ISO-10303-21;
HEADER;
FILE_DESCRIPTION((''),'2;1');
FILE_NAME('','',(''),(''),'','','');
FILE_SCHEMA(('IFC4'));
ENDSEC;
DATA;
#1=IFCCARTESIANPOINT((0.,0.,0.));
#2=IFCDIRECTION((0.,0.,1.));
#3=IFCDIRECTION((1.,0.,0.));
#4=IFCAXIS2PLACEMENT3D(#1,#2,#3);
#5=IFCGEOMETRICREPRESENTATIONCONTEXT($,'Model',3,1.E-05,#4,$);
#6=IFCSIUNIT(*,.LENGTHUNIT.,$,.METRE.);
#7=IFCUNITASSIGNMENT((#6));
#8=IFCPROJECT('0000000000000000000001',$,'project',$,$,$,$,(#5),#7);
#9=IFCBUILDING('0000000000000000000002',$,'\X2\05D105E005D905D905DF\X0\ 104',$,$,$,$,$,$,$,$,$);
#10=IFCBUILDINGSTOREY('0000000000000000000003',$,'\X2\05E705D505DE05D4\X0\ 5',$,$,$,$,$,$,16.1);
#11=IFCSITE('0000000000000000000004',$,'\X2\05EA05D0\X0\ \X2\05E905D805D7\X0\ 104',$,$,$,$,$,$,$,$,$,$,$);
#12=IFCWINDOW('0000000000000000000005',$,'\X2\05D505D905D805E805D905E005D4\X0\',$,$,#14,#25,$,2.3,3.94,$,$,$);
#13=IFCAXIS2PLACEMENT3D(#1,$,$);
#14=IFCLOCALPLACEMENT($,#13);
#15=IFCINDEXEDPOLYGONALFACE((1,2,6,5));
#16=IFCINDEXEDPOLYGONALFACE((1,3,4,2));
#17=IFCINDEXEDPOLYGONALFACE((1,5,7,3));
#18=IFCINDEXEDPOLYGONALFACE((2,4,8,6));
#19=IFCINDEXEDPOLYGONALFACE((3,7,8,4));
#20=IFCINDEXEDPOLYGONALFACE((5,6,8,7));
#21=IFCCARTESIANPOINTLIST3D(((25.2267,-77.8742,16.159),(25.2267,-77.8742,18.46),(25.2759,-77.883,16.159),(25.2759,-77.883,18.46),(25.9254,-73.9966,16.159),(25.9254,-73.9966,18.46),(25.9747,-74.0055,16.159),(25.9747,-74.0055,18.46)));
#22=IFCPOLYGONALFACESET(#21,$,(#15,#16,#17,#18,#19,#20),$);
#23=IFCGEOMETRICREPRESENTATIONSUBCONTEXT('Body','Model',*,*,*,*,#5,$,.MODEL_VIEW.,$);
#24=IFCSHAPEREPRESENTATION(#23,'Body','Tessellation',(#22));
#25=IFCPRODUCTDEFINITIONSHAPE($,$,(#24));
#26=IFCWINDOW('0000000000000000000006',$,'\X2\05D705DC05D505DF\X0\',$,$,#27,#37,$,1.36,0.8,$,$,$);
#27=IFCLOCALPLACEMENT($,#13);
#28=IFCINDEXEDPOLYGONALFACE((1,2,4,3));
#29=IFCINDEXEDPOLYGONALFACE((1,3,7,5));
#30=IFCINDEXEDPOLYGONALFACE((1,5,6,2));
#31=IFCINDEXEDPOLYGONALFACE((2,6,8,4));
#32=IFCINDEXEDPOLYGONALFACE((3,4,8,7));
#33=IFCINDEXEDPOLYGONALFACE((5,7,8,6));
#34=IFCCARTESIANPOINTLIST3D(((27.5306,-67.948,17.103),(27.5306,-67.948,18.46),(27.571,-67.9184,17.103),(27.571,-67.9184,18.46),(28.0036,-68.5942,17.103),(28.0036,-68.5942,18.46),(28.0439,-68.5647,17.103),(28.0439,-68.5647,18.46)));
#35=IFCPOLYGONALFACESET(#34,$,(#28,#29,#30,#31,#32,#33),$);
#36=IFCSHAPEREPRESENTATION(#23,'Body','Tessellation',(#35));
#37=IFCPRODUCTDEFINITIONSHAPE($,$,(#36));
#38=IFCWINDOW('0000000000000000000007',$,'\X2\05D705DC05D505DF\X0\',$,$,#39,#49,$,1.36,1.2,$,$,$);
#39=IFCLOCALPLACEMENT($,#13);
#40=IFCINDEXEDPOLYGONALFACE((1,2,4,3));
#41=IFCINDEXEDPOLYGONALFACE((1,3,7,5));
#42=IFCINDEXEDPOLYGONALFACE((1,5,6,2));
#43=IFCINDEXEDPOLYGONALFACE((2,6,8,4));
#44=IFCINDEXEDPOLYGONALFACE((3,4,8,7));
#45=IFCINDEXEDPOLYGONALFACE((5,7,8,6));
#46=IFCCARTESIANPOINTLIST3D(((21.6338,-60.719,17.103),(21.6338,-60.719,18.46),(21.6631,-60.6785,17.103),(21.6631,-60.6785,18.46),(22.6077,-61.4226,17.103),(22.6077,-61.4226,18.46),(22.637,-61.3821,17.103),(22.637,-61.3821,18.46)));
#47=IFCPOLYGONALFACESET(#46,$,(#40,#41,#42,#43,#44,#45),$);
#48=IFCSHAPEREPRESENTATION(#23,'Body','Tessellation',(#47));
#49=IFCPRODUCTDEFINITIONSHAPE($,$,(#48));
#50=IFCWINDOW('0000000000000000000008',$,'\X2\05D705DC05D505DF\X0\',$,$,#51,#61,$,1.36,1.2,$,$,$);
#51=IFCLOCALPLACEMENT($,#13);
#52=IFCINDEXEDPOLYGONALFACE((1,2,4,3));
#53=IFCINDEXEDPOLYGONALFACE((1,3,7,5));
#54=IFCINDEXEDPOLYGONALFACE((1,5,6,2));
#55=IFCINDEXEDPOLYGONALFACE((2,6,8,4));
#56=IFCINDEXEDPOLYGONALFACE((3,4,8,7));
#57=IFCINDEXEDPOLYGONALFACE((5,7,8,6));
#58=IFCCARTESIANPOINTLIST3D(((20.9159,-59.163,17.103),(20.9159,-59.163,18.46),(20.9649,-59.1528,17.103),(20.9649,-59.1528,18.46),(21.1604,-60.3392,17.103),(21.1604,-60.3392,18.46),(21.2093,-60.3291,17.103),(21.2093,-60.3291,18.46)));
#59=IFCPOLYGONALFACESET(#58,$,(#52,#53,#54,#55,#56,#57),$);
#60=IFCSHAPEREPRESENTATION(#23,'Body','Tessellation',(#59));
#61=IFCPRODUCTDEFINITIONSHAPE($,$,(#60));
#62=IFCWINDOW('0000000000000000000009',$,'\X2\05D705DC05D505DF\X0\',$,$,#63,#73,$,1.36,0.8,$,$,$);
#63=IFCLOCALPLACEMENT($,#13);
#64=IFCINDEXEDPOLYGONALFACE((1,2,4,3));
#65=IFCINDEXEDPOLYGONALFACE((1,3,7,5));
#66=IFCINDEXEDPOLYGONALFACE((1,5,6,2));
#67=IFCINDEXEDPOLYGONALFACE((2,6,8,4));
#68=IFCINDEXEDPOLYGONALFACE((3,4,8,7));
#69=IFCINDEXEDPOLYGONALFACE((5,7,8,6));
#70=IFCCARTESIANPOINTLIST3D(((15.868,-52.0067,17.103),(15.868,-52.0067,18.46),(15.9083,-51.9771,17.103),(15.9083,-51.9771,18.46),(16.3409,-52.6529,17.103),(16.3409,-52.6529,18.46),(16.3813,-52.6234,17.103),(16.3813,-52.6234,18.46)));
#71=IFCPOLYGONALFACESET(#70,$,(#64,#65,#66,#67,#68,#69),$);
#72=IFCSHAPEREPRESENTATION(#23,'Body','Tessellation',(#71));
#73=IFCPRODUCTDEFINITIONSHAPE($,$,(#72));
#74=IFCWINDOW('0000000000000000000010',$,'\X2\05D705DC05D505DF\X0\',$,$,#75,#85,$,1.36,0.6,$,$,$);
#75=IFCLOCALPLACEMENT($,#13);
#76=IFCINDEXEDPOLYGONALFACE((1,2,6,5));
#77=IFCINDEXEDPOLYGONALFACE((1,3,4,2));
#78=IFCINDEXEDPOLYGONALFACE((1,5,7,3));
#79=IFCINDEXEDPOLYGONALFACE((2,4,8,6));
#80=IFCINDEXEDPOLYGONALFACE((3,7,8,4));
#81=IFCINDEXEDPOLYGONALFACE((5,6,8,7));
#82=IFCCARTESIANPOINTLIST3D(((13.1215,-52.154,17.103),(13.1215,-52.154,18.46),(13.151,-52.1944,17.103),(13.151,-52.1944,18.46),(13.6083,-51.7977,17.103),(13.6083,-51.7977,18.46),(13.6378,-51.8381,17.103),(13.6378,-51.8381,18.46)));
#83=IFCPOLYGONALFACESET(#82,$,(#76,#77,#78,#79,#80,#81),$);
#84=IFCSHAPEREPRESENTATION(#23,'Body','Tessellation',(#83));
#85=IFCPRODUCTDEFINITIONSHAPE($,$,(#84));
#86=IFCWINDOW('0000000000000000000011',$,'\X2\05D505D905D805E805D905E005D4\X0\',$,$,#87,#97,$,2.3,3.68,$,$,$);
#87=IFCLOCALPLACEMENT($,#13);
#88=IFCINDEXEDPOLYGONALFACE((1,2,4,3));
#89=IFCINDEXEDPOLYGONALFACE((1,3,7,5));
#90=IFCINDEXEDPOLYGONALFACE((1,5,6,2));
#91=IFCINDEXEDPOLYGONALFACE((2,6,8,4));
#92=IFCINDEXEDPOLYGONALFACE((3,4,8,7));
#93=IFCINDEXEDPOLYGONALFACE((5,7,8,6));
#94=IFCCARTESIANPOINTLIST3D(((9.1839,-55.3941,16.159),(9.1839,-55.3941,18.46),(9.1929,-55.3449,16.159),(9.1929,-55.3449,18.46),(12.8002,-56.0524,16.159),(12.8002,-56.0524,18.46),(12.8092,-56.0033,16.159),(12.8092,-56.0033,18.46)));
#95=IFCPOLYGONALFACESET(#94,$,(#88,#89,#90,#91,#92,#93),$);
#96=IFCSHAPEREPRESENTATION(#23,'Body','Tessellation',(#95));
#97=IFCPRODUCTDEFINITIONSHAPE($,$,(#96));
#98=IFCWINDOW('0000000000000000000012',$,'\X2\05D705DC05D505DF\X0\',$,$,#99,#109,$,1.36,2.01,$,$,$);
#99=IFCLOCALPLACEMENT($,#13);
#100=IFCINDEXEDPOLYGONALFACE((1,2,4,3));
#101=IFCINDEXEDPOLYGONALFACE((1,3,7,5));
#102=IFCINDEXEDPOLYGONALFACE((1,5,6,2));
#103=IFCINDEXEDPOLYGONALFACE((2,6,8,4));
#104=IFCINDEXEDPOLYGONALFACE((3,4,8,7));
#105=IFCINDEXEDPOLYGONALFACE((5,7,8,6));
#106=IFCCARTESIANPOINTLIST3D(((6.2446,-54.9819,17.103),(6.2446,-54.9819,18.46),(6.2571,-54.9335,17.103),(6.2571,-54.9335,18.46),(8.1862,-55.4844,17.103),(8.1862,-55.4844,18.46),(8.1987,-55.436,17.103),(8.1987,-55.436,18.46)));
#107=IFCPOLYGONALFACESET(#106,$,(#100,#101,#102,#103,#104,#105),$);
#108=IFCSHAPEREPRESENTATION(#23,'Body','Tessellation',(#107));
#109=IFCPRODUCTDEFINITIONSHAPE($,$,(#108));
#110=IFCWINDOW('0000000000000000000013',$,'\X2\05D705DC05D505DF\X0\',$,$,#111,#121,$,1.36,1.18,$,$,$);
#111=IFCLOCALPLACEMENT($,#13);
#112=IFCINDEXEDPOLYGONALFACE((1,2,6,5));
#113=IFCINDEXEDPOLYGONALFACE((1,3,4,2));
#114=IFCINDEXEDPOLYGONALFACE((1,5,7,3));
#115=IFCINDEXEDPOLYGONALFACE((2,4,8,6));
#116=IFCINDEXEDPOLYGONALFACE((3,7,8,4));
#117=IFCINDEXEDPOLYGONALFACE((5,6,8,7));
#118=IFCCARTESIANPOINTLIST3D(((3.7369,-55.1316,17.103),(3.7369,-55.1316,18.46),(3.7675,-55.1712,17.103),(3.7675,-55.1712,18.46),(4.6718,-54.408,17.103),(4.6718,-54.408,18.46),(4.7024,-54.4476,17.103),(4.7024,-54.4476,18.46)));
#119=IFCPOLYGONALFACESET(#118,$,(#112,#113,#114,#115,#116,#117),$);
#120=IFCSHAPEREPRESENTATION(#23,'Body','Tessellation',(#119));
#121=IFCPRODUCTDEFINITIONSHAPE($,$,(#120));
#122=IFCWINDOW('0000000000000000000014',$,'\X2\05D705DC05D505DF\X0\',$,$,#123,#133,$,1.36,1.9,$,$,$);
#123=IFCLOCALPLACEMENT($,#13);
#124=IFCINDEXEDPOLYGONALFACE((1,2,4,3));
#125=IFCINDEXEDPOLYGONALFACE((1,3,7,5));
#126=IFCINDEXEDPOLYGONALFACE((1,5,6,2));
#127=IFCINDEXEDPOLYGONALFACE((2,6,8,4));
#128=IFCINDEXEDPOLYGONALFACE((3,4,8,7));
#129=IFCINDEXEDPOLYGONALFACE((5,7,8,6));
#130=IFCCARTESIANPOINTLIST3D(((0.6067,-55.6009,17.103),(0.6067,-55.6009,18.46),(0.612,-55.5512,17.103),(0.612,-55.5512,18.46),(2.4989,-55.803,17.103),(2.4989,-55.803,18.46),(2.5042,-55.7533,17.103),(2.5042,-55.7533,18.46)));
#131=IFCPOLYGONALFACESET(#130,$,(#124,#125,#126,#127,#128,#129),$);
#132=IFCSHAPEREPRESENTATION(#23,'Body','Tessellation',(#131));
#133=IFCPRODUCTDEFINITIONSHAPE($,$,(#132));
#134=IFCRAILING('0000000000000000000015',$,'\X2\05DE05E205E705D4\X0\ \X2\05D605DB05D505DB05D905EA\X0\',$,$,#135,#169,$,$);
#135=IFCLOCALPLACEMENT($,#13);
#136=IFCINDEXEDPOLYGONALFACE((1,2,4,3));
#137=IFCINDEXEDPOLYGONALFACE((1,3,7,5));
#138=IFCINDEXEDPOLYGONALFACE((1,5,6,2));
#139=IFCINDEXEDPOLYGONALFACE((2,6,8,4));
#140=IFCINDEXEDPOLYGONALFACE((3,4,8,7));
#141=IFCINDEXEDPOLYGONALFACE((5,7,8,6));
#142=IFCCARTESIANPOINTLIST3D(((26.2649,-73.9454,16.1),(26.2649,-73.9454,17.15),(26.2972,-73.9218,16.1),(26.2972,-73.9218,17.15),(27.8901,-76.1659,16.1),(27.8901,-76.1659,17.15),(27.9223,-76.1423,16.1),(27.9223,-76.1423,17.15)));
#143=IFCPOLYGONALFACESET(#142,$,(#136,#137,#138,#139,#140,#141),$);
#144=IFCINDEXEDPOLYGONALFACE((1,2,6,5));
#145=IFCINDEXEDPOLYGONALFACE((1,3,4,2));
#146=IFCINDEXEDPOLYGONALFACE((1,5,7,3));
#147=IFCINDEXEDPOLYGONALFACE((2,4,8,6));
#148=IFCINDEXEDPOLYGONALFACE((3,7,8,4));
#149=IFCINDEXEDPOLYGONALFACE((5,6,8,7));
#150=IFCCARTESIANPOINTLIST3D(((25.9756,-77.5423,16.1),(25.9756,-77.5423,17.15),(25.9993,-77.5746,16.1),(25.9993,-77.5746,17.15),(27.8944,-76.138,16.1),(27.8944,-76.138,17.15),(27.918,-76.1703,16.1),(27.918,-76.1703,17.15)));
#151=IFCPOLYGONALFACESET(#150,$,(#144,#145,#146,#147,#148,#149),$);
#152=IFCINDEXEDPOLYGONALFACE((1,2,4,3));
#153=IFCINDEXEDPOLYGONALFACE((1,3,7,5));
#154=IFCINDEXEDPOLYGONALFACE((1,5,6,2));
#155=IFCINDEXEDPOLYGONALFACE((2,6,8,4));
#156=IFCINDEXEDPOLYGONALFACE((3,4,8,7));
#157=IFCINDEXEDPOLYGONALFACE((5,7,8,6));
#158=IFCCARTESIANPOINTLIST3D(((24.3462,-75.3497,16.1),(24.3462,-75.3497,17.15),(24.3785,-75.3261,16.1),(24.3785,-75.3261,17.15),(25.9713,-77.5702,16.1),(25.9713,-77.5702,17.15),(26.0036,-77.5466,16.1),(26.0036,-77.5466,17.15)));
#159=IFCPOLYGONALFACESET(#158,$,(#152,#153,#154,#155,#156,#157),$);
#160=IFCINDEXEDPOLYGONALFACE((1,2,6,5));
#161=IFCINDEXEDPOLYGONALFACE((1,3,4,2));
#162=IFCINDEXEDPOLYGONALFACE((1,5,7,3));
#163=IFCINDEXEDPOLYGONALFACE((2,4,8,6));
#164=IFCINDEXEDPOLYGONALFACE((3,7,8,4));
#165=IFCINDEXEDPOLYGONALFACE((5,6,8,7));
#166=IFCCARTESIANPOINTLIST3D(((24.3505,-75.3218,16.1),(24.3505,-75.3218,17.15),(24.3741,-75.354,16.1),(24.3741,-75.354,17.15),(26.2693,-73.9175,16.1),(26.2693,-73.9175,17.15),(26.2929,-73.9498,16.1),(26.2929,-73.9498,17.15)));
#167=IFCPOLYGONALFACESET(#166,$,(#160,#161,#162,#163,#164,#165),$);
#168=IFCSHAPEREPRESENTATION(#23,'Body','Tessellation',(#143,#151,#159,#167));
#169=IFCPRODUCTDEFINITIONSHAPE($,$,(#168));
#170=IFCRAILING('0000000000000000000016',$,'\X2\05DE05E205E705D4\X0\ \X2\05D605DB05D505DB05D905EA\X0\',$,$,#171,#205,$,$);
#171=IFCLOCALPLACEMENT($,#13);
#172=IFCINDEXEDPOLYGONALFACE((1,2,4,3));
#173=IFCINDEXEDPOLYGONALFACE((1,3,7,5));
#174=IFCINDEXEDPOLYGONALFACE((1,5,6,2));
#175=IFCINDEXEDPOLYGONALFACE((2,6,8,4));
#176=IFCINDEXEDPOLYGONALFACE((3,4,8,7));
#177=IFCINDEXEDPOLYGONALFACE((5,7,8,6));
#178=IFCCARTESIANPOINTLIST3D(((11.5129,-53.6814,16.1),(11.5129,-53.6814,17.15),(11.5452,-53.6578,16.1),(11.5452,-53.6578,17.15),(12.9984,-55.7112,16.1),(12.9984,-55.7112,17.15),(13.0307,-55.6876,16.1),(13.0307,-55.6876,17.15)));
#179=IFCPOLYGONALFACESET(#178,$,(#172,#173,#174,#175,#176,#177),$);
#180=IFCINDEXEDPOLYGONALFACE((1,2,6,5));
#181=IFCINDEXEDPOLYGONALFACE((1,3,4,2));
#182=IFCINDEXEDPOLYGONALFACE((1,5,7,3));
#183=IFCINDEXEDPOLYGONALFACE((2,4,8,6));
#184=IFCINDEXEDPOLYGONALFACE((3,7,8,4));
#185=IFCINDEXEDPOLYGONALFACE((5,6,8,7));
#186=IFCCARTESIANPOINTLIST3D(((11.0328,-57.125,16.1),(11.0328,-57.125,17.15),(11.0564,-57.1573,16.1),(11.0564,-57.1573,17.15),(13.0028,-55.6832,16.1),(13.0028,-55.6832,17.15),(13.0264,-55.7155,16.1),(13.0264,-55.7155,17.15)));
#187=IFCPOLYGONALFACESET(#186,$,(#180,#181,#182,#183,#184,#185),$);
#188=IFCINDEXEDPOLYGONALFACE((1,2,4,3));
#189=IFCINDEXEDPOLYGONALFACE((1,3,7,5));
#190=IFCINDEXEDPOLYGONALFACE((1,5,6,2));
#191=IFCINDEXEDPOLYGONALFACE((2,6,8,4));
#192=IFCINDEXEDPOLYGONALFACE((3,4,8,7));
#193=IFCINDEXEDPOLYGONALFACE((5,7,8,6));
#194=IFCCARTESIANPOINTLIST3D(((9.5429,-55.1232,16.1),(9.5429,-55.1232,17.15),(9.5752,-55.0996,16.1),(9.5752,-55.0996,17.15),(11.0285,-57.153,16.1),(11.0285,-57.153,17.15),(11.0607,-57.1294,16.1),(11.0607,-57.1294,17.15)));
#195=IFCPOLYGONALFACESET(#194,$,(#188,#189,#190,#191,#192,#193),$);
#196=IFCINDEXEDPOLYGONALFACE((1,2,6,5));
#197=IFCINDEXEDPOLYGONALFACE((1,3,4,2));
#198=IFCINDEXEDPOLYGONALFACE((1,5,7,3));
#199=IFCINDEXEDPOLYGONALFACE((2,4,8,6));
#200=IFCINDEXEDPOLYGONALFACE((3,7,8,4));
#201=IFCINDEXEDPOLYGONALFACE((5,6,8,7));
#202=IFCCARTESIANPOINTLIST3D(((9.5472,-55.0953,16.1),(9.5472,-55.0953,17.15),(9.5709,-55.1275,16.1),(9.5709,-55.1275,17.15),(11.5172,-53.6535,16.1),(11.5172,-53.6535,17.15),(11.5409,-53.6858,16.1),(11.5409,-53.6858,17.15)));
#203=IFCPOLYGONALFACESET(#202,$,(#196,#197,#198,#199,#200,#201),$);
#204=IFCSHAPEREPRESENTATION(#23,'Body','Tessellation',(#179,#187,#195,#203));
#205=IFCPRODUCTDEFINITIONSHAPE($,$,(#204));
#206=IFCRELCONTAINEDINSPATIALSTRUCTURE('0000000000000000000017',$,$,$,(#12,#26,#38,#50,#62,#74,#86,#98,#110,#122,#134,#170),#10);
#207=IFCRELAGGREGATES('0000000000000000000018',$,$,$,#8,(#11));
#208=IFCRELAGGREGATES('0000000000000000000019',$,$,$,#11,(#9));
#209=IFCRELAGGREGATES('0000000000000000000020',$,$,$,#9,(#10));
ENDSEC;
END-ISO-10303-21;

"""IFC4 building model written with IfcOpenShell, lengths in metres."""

from ifc_helpers import new_model, si_unit, frame, origin_with_axes, context, subcontext, project, spatial, polyline, outline, extrude, element, save


model = new_model("IFC4")

# Units and contexts
model_context = context("Model", 3, precision=1e-05, world=origin_with_axes())
body_context = subcontext(model_context, "Body", "Model", "MODEL_VIEW")
ifc_project = project(units=[si_unit("LENGTHUNIT", "METRE")], contexts=[model_context])

# Site, building, storey
site = spatial("IfcSite", under=ifc_project, Name="תא שטח 104")
building = spatial("IfcBuilding", under=site, Name="בניין 104")
storey = spatial("IfcBuildingStorey", under=building, Name="קומה 5", Elevation=16.1)

# Windows
element("IfcWindow", 1, inside=storey, Name="ויטרינה", OverallHeight=2.3, OverallWidth=3.94, context=body_context, shape_type="SweptSolid", body=[
    extrude(outline(polyline([(25.2759, -77.883), (25.9747, -74.0055), (25.9254, -73.9966), (25.2267, -77.8742), (25.2759, -77.883)])), frame((0.0, 0.0, 16.159)), (0.0, 0.0, 1.0), 2.301),
])
element("IfcWindow", 2, inside=storey, Name="חלון", OverallHeight=1.36, OverallWidth=0.8, context=body_context, shape_type="SweptSolid", body=[
    extrude(outline(polyline([(28.0439, -68.5647), (27.571, -67.9184), (27.5306, -67.948), (28.0036, -68.5942), (28.0439, -68.5647)])), frame((0.0, 0.0, 17.103)), (0.0, 0.0, 1.0), 1.357),
])
element("IfcWindow", 3, inside=storey, Name="חלון", OverallHeight=1.36, OverallWidth=1.2, context=body_context, shape_type="SweptSolid", body=[
    extrude(outline(polyline([(22.637, -61.3821), (21.6631, -60.6785), (21.6338, -60.719), (22.6077, -61.4226), (22.637, -61.3821)])), frame((0.0, 0.0, 17.103)), (0.0, 0.0, 1.0), 1.357),
])
element("IfcWindow", 4, inside=storey, Name="חלון", OverallHeight=1.36, OverallWidth=1.2, context=body_context, shape_type="SweptSolid", body=[
    extrude(outline(polyline([(21.2093, -60.3291), (20.9649, -59.1528), (20.9159, -59.163), (21.1604, -60.3392), (21.2093, -60.3291)])), frame((0.0, 0.0, 17.103)), (0.0, 0.0, 1.0), 1.357),
])
element("IfcWindow", 5, inside=storey, Name="חלון", OverallHeight=1.36, OverallWidth=0.8, context=body_context, shape_type="SweptSolid", body=[
    extrude(outline(polyline([(16.3813, -52.6234), (15.9083, -51.9771), (15.868, -52.0067), (16.3409, -52.6529), (16.3813, -52.6234)])), frame((0.0, 0.0, 17.103)), (0.0, 0.0, 1.0), 1.357),
])
element("IfcWindow", 6, inside=storey, Name="חלון", OverallHeight=1.36, OverallWidth=0.6, context=body_context, shape_type="SweptSolid", body=[
    extrude(outline(polyline([(13.6083, -51.7977), (13.1215, -52.154), (13.151, -52.1944), (13.6378, -51.8381), (13.6083, -51.7977)])), frame((0.0, 0.0, 17.103)), (0.0, 0.0, 1.0), 1.357),
])
element("IfcWindow", 7, inside=storey, Name="ויטרינה", OverallHeight=2.3, OverallWidth=3.68, context=body_context, shape_type="SweptSolid", body=[
    extrude(outline(polyline([(12.8092, -56.0033), (9.1929, -55.3449), (9.1839, -55.3941), (12.8002, -56.0524), (12.8092, -56.0033)])), frame((0.0, 0.0, 16.159)), (0.0, 0.0, 1.0), 2.301),
])
element("IfcWindow", 8, inside=storey, Name="חלון", OverallHeight=1.36, OverallWidth=2.01, context=body_context, shape_type="SweptSolid", body=[
    extrude(outline(polyline([(8.1987, -55.436), (6.2571, -54.9335), (6.2446, -54.9819), (8.1862, -55.4844), (8.1987, -55.436)])), frame((0.0, 0.0, 17.103)), (0.0, 0.0, 1.0), 1.357),
])
element("IfcWindow", 9, inside=storey, Name="חלון", OverallHeight=1.36, OverallWidth=1.18, context=body_context, shape_type="SweptSolid", body=[
    extrude(outline(polyline([(4.6718, -54.408), (3.7369, -55.1316), (3.7675, -55.1712), (4.7024, -54.4476), (4.6718, -54.408)])), frame((0.0, 0.0, 17.103)), (0.0, 0.0, 1.0), 1.357),
])
element("IfcWindow", 10, inside=storey, Name="חלון", OverallHeight=1.36, OverallWidth=1.9, context=body_context, shape_type="SweptSolid", body=[
    extrude(outline(polyline([(2.5042, -55.7533), (0.612, -55.5512), (0.6067, -55.6009), (2.4989, -55.803), (2.5042, -55.7533)])), frame((0.0, 0.0, 17.103)), (0.0, 0.0, 1.0), 1.357),
])

# Railings
element("IfcRailing", 11, inside=storey, Name="מעקה זכוכית", context=body_context, shape_type="SweptSolid", body=[
    extrude(outline(polyline([(26.2649, -73.9454), (27.8901, -76.1659), (27.9223, -76.1423), (26.2972, -73.9218), (26.2649, -73.9454)])), frame((0.0, 0.0, 16.1)), (0.0, 0.0, 1.0), 1.05),
    extrude(outline(polyline([(27.8944, -76.138), (25.9756, -77.5423), (25.9993, -77.5746), (27.918, -76.1703), (27.8944, -76.138)])), frame((0.0, 0.0, 16.1)), (0.0, 0.0, 1.0), 1.05),
    extrude(outline(polyline([(26.0036, -77.5466), (24.3785, -75.3261), (24.3462, -75.3497), (25.9713, -77.5702), (26.0036, -77.5466)])), frame((0.0, 0.0, 16.1)), (0.0, 0.0, 1.0), 1.05),
    extrude(outline(polyline([(24.3741, -75.354), (26.2929, -73.9498), (26.2693, -73.9175), (24.3505, -75.3218), (24.3741, -75.354)])), frame((0.0, 0.0, 16.1)), (0.0, 0.0, 1.0), 1.05),
])
element("IfcRailing", 12, inside=storey, Name="מעקה זכוכית", context=body_context, shape_type="SweptSolid", body=[
    extrude(outline(polyline([(11.5129, -53.6814), (12.9984, -55.7112), (13.0307, -55.6876), (11.5452, -53.6578), (11.5129, -53.6814)])), frame((0.0, 0.0, 16.1)), (0.0, 0.0, 1.0), 1.05),
    extrude(outline(polyline([(13.0028, -55.6832), (11.0328, -57.125), (11.0564, -57.1573), (13.0264, -55.7155), (13.0028, -55.6832)])), frame((0.0, 0.0, 16.1)), (0.0, 0.0, 1.0), 1.05),
    extrude(outline(polyline([(11.0607, -57.1294), (9.5752, -55.0996), (9.5429, -55.1232), (11.0285, -57.153), (11.0607, -57.1294)])), frame((0.0, 0.0, 16.1)), (0.0, 0.0, 1.0), 1.05),
    extrude(outline(polyline([(9.5709, -55.1275), (11.5409, -53.6858), (11.5172, -53.6535), (9.5472, -55.0953), (9.5709, -55.1275)])), frame((0.0, 0.0, 16.1)), (0.0, 0.0, 1.0), 1.05),
])

save(model, "model.ifc")
